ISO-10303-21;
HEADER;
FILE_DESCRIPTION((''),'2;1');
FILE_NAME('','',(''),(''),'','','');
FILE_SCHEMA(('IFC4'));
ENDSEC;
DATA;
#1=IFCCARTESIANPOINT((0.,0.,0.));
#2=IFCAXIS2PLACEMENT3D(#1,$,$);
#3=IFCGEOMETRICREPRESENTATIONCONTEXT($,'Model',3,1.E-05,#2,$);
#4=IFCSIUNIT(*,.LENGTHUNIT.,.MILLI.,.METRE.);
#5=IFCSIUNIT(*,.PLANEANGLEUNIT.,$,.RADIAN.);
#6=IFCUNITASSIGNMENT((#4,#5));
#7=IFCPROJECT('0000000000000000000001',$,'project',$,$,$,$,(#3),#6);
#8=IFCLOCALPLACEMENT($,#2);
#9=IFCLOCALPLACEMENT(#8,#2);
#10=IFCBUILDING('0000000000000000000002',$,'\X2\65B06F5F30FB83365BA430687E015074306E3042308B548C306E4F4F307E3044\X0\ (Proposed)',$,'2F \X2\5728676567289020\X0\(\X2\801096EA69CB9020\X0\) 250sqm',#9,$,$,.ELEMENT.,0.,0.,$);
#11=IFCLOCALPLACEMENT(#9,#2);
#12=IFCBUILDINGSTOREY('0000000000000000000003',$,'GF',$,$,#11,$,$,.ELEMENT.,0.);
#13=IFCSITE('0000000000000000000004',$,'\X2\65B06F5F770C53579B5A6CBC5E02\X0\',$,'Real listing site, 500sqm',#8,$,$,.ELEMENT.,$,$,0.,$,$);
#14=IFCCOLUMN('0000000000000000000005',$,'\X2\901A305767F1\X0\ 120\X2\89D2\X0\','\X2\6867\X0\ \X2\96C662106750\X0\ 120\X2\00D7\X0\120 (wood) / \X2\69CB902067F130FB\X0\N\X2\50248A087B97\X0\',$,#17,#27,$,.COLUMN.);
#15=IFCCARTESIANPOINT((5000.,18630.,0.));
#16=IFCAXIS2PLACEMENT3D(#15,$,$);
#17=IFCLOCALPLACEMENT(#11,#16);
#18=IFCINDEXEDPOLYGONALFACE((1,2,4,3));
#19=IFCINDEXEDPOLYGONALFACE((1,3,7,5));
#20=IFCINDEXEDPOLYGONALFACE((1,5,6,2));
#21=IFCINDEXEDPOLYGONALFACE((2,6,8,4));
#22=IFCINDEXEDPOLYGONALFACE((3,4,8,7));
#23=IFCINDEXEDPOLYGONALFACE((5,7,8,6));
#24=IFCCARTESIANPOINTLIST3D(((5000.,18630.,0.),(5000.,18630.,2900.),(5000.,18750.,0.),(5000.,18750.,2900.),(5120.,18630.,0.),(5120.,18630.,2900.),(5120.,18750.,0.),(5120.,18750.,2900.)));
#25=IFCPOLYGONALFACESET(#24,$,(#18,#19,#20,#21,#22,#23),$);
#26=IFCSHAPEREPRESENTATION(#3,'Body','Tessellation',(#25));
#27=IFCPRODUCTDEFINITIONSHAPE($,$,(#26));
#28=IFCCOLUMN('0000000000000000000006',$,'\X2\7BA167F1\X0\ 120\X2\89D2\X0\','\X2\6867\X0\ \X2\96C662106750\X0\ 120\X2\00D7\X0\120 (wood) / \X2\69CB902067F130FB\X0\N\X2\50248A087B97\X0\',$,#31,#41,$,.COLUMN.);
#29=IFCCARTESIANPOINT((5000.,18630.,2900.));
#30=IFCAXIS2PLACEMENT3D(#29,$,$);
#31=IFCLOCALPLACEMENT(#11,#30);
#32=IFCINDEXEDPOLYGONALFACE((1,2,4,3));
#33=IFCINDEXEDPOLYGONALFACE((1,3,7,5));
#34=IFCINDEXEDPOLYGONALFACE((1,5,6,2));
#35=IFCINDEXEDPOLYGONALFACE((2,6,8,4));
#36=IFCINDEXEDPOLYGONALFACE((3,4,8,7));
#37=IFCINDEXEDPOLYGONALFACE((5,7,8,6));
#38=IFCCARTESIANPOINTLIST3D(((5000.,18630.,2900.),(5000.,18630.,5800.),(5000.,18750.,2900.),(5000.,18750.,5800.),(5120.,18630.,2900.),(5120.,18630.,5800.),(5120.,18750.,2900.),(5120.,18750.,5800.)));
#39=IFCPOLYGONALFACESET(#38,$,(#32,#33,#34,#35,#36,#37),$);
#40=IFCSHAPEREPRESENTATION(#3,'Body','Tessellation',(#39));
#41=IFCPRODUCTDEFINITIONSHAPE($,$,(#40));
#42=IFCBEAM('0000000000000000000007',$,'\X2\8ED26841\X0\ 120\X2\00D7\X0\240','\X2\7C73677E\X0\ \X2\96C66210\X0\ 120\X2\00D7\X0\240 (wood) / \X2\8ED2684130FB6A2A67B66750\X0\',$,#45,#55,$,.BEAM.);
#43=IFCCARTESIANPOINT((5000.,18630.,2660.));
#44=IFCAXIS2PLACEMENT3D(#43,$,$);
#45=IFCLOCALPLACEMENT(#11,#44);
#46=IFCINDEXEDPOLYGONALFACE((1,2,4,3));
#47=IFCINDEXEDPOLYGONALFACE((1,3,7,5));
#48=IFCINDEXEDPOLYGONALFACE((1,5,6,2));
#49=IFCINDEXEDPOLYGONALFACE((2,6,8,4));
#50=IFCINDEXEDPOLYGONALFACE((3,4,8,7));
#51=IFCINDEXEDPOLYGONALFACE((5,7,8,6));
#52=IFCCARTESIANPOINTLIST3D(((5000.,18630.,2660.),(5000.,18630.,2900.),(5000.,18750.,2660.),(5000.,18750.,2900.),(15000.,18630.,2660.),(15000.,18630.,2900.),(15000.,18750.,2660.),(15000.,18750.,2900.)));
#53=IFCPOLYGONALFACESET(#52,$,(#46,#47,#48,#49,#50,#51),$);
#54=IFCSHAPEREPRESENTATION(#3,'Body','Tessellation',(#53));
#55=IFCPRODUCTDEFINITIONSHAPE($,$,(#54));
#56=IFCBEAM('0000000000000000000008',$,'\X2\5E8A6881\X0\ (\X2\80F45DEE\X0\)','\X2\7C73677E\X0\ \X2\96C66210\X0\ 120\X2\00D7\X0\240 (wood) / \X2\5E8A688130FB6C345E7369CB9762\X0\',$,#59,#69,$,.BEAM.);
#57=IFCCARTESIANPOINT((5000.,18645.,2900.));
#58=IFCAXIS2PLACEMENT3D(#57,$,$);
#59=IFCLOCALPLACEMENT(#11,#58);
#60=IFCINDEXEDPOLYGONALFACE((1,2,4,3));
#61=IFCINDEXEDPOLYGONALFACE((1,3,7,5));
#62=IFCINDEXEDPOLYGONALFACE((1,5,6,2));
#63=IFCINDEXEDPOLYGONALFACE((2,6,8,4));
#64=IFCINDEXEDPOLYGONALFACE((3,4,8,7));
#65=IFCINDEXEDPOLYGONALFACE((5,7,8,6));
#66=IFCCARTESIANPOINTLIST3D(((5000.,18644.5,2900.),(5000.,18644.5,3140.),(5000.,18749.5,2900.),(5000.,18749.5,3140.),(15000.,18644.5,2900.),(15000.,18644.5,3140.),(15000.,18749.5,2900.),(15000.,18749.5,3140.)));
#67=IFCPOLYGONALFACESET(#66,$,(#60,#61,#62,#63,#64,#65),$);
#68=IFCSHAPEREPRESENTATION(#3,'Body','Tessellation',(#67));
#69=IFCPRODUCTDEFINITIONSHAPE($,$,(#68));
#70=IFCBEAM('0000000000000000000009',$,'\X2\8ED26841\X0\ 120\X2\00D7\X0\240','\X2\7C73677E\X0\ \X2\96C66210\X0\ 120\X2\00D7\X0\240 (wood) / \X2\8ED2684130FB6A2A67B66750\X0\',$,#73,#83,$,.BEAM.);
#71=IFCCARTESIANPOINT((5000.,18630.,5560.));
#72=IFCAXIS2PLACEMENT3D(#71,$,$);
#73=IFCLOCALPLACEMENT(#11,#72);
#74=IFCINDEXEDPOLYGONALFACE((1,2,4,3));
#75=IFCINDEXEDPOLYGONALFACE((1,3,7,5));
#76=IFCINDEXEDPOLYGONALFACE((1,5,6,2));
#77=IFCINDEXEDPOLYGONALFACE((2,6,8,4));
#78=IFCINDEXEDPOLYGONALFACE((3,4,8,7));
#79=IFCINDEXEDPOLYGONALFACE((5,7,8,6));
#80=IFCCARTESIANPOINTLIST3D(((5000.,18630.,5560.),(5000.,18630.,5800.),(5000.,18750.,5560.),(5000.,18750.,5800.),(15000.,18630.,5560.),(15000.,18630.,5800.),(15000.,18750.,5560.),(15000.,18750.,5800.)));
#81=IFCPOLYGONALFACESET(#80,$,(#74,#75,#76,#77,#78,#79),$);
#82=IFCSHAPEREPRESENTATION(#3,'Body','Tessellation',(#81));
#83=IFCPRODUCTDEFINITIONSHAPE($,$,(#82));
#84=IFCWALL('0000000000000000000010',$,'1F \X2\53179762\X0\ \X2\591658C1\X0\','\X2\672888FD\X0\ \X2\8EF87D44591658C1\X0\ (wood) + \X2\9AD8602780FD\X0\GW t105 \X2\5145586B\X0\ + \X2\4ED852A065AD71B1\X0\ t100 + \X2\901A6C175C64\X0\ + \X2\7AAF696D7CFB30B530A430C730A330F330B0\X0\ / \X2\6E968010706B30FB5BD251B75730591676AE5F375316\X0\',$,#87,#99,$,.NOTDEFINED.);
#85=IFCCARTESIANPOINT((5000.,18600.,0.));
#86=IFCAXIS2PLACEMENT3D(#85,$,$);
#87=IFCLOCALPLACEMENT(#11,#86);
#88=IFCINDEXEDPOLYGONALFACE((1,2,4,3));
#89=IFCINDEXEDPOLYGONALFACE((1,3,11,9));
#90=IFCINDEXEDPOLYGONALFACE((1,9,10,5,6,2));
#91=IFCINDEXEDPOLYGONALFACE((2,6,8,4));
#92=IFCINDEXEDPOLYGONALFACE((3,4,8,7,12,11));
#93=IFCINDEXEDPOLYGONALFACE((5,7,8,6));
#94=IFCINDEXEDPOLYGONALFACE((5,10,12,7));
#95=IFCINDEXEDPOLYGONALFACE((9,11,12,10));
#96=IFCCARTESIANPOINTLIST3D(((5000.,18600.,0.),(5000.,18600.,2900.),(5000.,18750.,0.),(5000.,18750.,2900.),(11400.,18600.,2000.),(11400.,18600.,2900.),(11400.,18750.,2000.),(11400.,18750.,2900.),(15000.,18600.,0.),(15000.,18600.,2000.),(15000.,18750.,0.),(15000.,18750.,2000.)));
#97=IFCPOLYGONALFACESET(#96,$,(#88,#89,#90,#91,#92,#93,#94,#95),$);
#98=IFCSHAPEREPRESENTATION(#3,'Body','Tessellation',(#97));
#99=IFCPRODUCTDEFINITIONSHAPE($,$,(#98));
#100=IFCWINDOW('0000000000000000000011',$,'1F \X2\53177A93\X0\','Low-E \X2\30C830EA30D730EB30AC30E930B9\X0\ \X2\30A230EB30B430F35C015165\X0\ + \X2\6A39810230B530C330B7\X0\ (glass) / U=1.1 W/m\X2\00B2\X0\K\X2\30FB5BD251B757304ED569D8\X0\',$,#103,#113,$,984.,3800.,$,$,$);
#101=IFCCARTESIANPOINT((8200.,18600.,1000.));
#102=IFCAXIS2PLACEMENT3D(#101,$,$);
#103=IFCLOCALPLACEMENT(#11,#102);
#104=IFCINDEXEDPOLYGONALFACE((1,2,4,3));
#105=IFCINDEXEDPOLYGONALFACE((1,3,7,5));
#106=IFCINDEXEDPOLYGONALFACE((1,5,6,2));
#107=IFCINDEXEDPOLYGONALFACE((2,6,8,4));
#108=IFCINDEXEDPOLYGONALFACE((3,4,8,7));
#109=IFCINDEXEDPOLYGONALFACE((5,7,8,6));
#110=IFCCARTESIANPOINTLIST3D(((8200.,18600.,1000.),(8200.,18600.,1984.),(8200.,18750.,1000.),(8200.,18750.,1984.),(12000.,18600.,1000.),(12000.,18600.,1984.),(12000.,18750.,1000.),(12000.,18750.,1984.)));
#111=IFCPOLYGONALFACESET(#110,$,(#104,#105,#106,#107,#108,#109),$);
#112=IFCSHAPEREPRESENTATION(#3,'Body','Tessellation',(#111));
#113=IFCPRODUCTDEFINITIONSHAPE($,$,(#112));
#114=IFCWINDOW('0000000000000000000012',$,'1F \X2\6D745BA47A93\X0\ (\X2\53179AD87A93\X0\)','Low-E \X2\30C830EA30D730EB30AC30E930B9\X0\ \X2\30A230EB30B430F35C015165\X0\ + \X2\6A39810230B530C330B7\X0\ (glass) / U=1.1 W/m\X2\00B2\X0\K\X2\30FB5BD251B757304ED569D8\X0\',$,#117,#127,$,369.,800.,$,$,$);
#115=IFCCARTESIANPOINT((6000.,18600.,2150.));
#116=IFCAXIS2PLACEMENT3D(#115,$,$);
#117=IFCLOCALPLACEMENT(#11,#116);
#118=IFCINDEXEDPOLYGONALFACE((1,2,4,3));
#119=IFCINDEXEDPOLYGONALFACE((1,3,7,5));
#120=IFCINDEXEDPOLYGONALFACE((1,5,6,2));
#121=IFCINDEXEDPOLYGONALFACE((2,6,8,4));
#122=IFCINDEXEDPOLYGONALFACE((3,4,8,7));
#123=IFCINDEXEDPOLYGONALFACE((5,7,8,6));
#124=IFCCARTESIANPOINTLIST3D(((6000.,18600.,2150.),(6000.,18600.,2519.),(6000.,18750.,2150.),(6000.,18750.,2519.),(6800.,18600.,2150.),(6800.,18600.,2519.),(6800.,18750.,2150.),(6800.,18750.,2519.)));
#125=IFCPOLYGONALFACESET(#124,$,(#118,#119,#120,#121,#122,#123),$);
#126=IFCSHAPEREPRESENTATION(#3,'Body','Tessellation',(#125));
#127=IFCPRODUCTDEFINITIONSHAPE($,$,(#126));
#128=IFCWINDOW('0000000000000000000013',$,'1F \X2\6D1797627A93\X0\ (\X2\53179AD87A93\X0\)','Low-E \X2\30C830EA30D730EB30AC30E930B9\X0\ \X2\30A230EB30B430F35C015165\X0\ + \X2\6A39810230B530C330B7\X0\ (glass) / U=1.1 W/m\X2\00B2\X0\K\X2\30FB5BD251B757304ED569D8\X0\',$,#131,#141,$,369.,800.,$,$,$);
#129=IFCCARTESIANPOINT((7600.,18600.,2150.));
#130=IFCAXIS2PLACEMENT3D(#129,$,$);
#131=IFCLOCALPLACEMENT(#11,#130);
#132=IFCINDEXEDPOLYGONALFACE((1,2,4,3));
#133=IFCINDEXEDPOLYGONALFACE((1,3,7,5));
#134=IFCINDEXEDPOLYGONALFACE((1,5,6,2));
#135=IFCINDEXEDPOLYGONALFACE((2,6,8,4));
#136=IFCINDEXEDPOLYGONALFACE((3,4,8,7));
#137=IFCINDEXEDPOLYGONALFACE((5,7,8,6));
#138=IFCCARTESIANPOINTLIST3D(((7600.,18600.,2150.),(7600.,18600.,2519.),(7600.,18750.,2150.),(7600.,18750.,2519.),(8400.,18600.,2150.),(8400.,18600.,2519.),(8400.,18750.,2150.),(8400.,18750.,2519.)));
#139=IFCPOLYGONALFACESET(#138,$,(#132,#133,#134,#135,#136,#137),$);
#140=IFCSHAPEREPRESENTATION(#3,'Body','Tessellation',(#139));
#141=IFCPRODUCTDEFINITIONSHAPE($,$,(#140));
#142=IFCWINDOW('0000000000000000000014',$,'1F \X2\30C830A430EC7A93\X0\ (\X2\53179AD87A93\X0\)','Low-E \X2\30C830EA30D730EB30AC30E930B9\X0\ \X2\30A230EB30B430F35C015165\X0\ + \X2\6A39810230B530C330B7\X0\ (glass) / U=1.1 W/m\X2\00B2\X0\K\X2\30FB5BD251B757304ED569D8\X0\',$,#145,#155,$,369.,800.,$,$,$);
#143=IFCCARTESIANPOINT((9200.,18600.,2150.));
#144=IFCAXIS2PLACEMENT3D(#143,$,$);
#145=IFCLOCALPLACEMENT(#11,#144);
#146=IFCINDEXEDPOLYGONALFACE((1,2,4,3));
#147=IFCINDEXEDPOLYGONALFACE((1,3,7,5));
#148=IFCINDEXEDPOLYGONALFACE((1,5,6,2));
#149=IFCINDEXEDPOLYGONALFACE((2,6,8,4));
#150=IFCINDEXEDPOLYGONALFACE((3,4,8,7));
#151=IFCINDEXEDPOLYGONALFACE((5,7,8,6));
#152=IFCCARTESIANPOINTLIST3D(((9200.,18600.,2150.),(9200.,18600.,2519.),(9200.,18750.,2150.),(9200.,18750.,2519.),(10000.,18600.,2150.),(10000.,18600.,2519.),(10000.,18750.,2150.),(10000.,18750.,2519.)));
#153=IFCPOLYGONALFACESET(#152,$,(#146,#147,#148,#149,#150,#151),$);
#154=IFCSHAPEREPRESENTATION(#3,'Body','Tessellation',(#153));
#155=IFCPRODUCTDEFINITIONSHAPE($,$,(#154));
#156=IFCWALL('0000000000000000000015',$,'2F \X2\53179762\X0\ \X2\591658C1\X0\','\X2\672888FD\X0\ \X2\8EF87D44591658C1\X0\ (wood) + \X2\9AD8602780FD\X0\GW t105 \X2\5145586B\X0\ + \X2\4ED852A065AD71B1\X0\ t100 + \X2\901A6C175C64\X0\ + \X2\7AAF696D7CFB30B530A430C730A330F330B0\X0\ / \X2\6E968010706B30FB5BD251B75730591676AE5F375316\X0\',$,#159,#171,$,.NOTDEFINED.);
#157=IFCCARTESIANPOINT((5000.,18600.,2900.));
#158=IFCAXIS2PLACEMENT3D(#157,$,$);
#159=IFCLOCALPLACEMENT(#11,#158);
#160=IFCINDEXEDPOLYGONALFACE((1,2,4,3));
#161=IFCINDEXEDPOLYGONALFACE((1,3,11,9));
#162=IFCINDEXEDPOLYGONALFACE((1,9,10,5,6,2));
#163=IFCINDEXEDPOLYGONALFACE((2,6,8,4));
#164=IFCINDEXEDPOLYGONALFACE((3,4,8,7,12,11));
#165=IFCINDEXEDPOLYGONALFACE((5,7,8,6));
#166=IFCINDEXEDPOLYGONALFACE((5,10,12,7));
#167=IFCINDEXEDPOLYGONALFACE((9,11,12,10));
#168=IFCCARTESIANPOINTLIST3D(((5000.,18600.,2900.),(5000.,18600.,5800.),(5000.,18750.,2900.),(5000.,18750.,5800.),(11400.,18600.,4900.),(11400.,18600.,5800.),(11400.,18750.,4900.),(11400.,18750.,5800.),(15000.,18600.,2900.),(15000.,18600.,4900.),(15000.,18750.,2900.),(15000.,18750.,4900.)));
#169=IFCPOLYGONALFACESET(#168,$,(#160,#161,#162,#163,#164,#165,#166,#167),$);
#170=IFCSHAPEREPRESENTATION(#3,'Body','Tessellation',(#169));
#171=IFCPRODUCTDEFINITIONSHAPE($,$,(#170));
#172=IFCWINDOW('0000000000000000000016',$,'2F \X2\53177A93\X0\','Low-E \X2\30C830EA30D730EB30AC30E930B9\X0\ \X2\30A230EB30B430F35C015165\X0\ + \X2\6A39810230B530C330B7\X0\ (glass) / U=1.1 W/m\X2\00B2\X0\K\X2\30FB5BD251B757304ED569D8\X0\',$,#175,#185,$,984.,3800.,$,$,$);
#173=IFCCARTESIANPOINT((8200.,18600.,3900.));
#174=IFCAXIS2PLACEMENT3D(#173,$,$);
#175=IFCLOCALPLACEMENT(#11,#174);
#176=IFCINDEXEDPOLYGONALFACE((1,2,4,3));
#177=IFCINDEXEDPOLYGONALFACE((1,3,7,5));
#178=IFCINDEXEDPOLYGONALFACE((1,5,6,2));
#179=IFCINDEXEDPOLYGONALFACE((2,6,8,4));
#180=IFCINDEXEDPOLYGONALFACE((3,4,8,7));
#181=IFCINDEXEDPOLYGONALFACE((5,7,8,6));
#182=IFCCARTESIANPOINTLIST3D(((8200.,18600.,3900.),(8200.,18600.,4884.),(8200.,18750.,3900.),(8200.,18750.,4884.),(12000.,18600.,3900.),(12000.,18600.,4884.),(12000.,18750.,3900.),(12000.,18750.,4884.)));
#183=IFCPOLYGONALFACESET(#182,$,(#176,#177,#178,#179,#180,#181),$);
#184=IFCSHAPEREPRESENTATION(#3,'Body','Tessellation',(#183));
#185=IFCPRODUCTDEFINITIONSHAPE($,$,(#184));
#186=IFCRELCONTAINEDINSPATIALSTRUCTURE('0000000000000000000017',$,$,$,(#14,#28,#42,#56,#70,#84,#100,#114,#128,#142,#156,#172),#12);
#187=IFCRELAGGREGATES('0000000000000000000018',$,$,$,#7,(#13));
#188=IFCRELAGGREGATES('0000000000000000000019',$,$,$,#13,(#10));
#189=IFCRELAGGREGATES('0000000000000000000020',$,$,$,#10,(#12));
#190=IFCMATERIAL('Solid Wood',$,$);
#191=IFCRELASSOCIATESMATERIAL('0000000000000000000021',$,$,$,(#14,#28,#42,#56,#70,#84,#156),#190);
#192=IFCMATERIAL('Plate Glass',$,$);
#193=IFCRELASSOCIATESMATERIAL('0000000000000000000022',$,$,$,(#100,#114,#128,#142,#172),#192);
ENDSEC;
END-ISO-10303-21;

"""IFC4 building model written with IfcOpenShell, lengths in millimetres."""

from ifc_helpers import new_model, si_unit, frame, frame_2d, origin, place, context, project, spatial, rectangle, extrude, material, element, fill, save


model = new_model("IFC4")

# Units and contexts
model_context = context("Model", 3, precision=1e-05, world=origin())
ifc_project = project(units=[si_unit("LENGTHUNIT", "METRE", prefix="MILLI"), si_unit("PLANEANGLEUNIT", "RADIAN")], contexts=[model_context])

# Site, building, storey
site_placement = place(None, origin())
site = spatial("IfcSite", under=ifc_project, at=site_placement, Name="新潟県南魚沼市", ObjectType="Real listing site, 500sqm", CompositionType="ELEMENT", RefElevation=0.0)
building_placement = place(site_placement, origin())
building = spatial("IfcBuilding", under=site, at=building_placement, Name="新潟・茶室と縁側のある和の住まい (Proposed)", ObjectType="2F 在来木造(耐雪構造) 250sqm", CompositionType="ELEMENT", ElevationOfRefHeight=0.0, ElevationOfTerrain=0.0)
storey_placement = place(building_placement, origin())
storey = spatial("IfcBuildingStorey", under=building, at=storey_placement, Name="GF", CompositionType="ELEMENT", Elevation=0.0)

# Columns
ifc_material_1 = material(Name="Solid Wood")
column_1_placement = place(storey_placement, frame((5000.0, 18630.0, 0.0)))
element("IfcColumn", 1, at=column_1_placement, inside=storey, material=ifc_material_1, Name="通し柱 120角", Description="桧 集成材 120×120 (wood) / 構造柱・N値計算", PredefinedType="COLUMN", context=model_context, shape_type="SweptSolid", body=[
    extrude(rectangle(XDim=120.0, YDim=120.0, at=frame_2d((60.0, 60.0))), frame((5000.0, 18630.0, 0.0)), (0.0, 0.0, 1.0), 2900.0),
])
column_2_placement = place(storey_placement, frame((5000.0, 18630.0, 2900.0)))
element("IfcColumn", 2, at=column_2_placement, inside=storey, material=ifc_material_1, Name="管柱 120角", Description="桧 集成材 120×120 (wood) / 構造柱・N値計算", PredefinedType="COLUMN", context=model_context, shape_type="SweptSolid", body=[
    extrude(rectangle(XDim=120.0, YDim=120.0, at=frame_2d((60.0, 60.0))), frame((5000.0, 18630.0, 2900.0)), (0.0, 0.0, 1.0), 2900.0),
])

# Beams
beam_1_placement = place(storey_placement, frame((5000.0, 18630.0, 2660.0)))
element("IfcBeam", 3, at=beam_1_placement, inside=storey, material=ifc_material_1, Name="軒桁 120×240", Description="米松 集成 120×240 (wood) / 軒桁・横架材", PredefinedType="BEAM", context=model_context, shape_type="SweptSolid", body=[
    extrude(rectangle(XDim=10000.0, YDim=120.0, at=frame_2d((5000.0, 60.0))), frame((5000.0, 18630.0, 2660.0)), (0.0, 0.0, 1.0), 240.0),
])
beam_2_placement = place(storey_placement, frame((5000.0, 18645.0, 2900.0)))
element("IfcBeam", 4, at=beam_2_placement, inside=storey, material=ifc_material_1, Name="床梁 (胴差)", Description="米松 集成 120×240 (wood) / 床梁・水平構面", PredefinedType="BEAM", context=model_context, shape_type="SweptSolid", body=[
    extrude(rectangle(XDim=10000.0, YDim=105.0, at=frame_2d((5000.0, 52.0))), frame((5000.0, 18645.0, 2900.0)), (0.0, 0.0, 1.0), 240.0),
])
beam_3_placement = place(storey_placement, frame((5000.0, 18630.0, 5560.0)))
element("IfcBeam", 5, at=beam_3_placement, inside=storey, material=ifc_material_1, Name="軒桁 120×240", Description="米松 集成 120×240 (wood) / 軒桁・横架材", PredefinedType="BEAM", context=model_context, shape_type="SweptSolid", body=[
    extrude(rectangle(XDim=10000.0, YDim=120.0, at=frame_2d((5000.0, 60.0))), frame((5000.0, 18630.0, 5560.0)), (0.0, 0.0, 1.0), 240.0),
])

# Wall, openings, windows
wall_1_placement = place(storey_placement, frame((5000.0, 18600.0, 0.0)))
wall_1 = element("IfcWall", 6, at=wall_1_placement, inside=storey, material=ifc_material_1, Name="1F 北面 外壁", Description="木製 軸組外壁 (wood) + 高性能GW t105 充填 + 付加断熱 t100 + 通気層 + 窯業系サイディング / 準耐火・寒冷地外皮強化", PredefinedType="NOTDEFINED", context=model_context, shape_type="SweptSolid", body=[
    extrude(rectangle(XDim=10000.0, YDim=150.0, at=frame_2d((5000.0, 75.0))), frame((5000.0, 18600.0, 0.0)), (0.0, 0.0, 1.0), 2900.0),
])
opening_1_placement = place(storey_placement, frame((8200.0, 18600.0, 1000.0)))
opening_1 = element("IfcOpeningElement", 7, at=opening_1_placement, cuts=wall_1, PredefinedType="NOTDEFINED", context=model_context, shape_type="SweptSolid", body=[
    extrude(rectangle(XDim=3800.0, YDim=150.0, at=frame_2d((1900.0, 75.0))), frame((8200.0, 18600.0, 1000.0)), (0.0, 0.0, 1.0), 984.0),
])
opening_2_placement = place(storey_placement, frame((6000.0, 18600.0, 2150.0)))
opening_2 = element("IfcOpeningElement", 8, at=opening_2_placement, cuts=wall_1, PredefinedType="NOTDEFINED", context=model_context, shape_type="SweptSolid", body=[
    extrude(rectangle(XDim=800.0, YDim=150.0, at=frame_2d((400.0, 75.0))), frame((6000.0, 18600.0, 2150.0)), (0.0, 0.0, 1.0), 369.0),
])
opening_3_placement = place(storey_placement, frame((7600.0, 18600.0, 2150.0)))
opening_3 = element("IfcOpeningElement", 9, at=opening_3_placement, cuts=wall_1, PredefinedType="NOTDEFINED", context=model_context, shape_type="SweptSolid", body=[
    extrude(rectangle(XDim=800.0, YDim=150.0, at=frame_2d((400.0, 75.0))), frame((7600.0, 18600.0, 2150.0)), (0.0, 0.0, 1.0), 369.0),
])
opening_4_placement = place(storey_placement, frame((9200.0, 18600.0, 2150.0)))
opening_4 = element("IfcOpeningElement", 10, at=opening_4_placement, cuts=wall_1, PredefinedType="NOTDEFINED", context=model_context, shape_type="SweptSolid", body=[
    extrude(rectangle(XDim=800.0, YDim=150.0, at=frame_2d((400.0, 75.0))), frame((9200.0, 18600.0, 2150.0)), (0.0, 0.0, 1.0), 369.0),
])
ifc_material_2 = material(Name="Plate Glass")
window_1_placement = place(storey_placement, frame((8200.0, 18600.0, 1000.0)))
window_1 = element("IfcWindow", 11, at=window_1_placement, inside=storey, material=ifc_material_2, Name="1F 北窓", Description="Low-E トリプルガラス アルゴン封入 + 樹脂サッシ (glass) / U=1.1 W/m²K・寒冷地仕様", OverallHeight=984.0, OverallWidth=3800.0, context=model_context, shape_type="SweptSolid", body=[
    extrude(rectangle(XDim=3800.0, YDim=150.0, at=frame_2d((1900.0, 75.0))), frame((8200.0, 18600.0, 1000.0)), (0.0, 0.0, 1.0), 984.0),
])
fill(opening_1, window_1)
window_2_placement = place(storey_placement, frame((6000.0, 18600.0, 2150.0)))
window_2 = element("IfcWindow", 12, at=window_2_placement, inside=storey, material=ifc_material_2, Name="1F 浴室窓 (北高窓)", Description="Low-E トリプルガラス アルゴン封入 + 樹脂サッシ (glass) / U=1.1 W/m²K・寒冷地仕様", OverallHeight=369.0, OverallWidth=800.0, context=model_context, shape_type="SweptSolid", body=[
    extrude(rectangle(XDim=800.0, YDim=150.0, at=frame_2d((400.0, 75.0))), frame((6000.0, 18600.0, 2150.0)), (0.0, 0.0, 1.0), 369.0),
])
fill(opening_2, window_2)
window_3_placement = place(storey_placement, frame((7600.0, 18600.0, 2150.0)))
window_3 = element("IfcWindow", 13, at=window_3_placement, inside=storey, material=ifc_material_2, Name="1F 洗面窓 (北高窓)", Description="Low-E トリプルガラス アルゴン封入 + 樹脂サッシ (glass) / U=1.1 W/m²K・寒冷地仕様", OverallHeight=369.0, OverallWidth=800.0, context=model_context, shape_type="SweptSolid", body=[
    extrude(rectangle(XDim=800.0, YDim=150.0, at=frame_2d((400.0, 75.0))), frame((7600.0, 18600.0, 2150.0)), (0.0, 0.0, 1.0), 369.0),
])
fill(opening_3, window_3)
window_4_placement = place(storey_placement, frame((9200.0, 18600.0, 2150.0)))
window_4 = element("IfcWindow", 14, at=window_4_placement, inside=storey, material=ifc_material_2, Name="1F トイレ窓 (北高窓)", Description="Low-E トリプルガラス アルゴン封入 + 樹脂サッシ (glass) / U=1.1 W/m²K・寒冷地仕様", OverallHeight=369.0, OverallWidth=800.0, context=model_context, shape_type="SweptSolid", body=[
    extrude(rectangle(XDim=800.0, YDim=150.0, at=frame_2d((400.0, 75.0))), frame((9200.0, 18600.0, 2150.0)), (0.0, 0.0, 1.0), 369.0),
])
fill(opening_4, window_4)

# Wall, opening, window
wall_2_placement = place(storey_placement, frame((5000.0, 18600.0, 2900.0)))
wall_2 = element("IfcWall", 15, at=wall_2_placement, inside=storey, material=ifc_material_1, Name="2F 北面 外壁", Description="木製 軸組外壁 (wood) + 高性能GW t105 充填 + 付加断熱 t100 + 通気層 + 窯業系サイディング / 準耐火・寒冷地外皮強化", PredefinedType="NOTDEFINED", context=model_context, shape_type="SweptSolid", body=[
    extrude(rectangle(XDim=10000.0, YDim=150.0, at=frame_2d((5000.0, 75.0))), frame((5000.0, 18600.0, 2900.0)), (0.0, 0.0, 1.0), 2900.0),
])
opening_5_placement = place(storey_placement, frame((8200.0, 18600.0, 3900.0)))
opening_5 = element("IfcOpeningElement", 16, at=opening_5_placement, cuts=wall_2, PredefinedType="NOTDEFINED", context=model_context, shape_type="SweptSolid", body=[
    extrude(rectangle(XDim=3800.0, YDim=150.0, at=frame_2d((1900.0, 75.0))), frame((8200.0, 18600.0, 3900.0)), (0.0, 0.0, 1.0), 984.0),
])
window_5_placement = place(storey_placement, frame((8200.0, 18600.0, 3900.0)))
window_5 = element("IfcWindow", 17, at=window_5_placement, inside=storey, material=ifc_material_2, Name="2F 北窓", Description="Low-E トリプルガラス アルゴン封入 + 樹脂サッシ (glass) / U=1.1 W/m²K・寒冷地仕様", OverallHeight=984.0, OverallWidth=3800.0, context=model_context, shape_type="SweptSolid", body=[
    extrude(rectangle(XDim=3800.0, YDim=150.0, at=frame_2d((1900.0, 75.0))), frame((8200.0, 18600.0, 3900.0)), (0.0, 0.0, 1.0), 984.0),
])
fill(opening_5, window_5)

save(model, "model.ifc")
